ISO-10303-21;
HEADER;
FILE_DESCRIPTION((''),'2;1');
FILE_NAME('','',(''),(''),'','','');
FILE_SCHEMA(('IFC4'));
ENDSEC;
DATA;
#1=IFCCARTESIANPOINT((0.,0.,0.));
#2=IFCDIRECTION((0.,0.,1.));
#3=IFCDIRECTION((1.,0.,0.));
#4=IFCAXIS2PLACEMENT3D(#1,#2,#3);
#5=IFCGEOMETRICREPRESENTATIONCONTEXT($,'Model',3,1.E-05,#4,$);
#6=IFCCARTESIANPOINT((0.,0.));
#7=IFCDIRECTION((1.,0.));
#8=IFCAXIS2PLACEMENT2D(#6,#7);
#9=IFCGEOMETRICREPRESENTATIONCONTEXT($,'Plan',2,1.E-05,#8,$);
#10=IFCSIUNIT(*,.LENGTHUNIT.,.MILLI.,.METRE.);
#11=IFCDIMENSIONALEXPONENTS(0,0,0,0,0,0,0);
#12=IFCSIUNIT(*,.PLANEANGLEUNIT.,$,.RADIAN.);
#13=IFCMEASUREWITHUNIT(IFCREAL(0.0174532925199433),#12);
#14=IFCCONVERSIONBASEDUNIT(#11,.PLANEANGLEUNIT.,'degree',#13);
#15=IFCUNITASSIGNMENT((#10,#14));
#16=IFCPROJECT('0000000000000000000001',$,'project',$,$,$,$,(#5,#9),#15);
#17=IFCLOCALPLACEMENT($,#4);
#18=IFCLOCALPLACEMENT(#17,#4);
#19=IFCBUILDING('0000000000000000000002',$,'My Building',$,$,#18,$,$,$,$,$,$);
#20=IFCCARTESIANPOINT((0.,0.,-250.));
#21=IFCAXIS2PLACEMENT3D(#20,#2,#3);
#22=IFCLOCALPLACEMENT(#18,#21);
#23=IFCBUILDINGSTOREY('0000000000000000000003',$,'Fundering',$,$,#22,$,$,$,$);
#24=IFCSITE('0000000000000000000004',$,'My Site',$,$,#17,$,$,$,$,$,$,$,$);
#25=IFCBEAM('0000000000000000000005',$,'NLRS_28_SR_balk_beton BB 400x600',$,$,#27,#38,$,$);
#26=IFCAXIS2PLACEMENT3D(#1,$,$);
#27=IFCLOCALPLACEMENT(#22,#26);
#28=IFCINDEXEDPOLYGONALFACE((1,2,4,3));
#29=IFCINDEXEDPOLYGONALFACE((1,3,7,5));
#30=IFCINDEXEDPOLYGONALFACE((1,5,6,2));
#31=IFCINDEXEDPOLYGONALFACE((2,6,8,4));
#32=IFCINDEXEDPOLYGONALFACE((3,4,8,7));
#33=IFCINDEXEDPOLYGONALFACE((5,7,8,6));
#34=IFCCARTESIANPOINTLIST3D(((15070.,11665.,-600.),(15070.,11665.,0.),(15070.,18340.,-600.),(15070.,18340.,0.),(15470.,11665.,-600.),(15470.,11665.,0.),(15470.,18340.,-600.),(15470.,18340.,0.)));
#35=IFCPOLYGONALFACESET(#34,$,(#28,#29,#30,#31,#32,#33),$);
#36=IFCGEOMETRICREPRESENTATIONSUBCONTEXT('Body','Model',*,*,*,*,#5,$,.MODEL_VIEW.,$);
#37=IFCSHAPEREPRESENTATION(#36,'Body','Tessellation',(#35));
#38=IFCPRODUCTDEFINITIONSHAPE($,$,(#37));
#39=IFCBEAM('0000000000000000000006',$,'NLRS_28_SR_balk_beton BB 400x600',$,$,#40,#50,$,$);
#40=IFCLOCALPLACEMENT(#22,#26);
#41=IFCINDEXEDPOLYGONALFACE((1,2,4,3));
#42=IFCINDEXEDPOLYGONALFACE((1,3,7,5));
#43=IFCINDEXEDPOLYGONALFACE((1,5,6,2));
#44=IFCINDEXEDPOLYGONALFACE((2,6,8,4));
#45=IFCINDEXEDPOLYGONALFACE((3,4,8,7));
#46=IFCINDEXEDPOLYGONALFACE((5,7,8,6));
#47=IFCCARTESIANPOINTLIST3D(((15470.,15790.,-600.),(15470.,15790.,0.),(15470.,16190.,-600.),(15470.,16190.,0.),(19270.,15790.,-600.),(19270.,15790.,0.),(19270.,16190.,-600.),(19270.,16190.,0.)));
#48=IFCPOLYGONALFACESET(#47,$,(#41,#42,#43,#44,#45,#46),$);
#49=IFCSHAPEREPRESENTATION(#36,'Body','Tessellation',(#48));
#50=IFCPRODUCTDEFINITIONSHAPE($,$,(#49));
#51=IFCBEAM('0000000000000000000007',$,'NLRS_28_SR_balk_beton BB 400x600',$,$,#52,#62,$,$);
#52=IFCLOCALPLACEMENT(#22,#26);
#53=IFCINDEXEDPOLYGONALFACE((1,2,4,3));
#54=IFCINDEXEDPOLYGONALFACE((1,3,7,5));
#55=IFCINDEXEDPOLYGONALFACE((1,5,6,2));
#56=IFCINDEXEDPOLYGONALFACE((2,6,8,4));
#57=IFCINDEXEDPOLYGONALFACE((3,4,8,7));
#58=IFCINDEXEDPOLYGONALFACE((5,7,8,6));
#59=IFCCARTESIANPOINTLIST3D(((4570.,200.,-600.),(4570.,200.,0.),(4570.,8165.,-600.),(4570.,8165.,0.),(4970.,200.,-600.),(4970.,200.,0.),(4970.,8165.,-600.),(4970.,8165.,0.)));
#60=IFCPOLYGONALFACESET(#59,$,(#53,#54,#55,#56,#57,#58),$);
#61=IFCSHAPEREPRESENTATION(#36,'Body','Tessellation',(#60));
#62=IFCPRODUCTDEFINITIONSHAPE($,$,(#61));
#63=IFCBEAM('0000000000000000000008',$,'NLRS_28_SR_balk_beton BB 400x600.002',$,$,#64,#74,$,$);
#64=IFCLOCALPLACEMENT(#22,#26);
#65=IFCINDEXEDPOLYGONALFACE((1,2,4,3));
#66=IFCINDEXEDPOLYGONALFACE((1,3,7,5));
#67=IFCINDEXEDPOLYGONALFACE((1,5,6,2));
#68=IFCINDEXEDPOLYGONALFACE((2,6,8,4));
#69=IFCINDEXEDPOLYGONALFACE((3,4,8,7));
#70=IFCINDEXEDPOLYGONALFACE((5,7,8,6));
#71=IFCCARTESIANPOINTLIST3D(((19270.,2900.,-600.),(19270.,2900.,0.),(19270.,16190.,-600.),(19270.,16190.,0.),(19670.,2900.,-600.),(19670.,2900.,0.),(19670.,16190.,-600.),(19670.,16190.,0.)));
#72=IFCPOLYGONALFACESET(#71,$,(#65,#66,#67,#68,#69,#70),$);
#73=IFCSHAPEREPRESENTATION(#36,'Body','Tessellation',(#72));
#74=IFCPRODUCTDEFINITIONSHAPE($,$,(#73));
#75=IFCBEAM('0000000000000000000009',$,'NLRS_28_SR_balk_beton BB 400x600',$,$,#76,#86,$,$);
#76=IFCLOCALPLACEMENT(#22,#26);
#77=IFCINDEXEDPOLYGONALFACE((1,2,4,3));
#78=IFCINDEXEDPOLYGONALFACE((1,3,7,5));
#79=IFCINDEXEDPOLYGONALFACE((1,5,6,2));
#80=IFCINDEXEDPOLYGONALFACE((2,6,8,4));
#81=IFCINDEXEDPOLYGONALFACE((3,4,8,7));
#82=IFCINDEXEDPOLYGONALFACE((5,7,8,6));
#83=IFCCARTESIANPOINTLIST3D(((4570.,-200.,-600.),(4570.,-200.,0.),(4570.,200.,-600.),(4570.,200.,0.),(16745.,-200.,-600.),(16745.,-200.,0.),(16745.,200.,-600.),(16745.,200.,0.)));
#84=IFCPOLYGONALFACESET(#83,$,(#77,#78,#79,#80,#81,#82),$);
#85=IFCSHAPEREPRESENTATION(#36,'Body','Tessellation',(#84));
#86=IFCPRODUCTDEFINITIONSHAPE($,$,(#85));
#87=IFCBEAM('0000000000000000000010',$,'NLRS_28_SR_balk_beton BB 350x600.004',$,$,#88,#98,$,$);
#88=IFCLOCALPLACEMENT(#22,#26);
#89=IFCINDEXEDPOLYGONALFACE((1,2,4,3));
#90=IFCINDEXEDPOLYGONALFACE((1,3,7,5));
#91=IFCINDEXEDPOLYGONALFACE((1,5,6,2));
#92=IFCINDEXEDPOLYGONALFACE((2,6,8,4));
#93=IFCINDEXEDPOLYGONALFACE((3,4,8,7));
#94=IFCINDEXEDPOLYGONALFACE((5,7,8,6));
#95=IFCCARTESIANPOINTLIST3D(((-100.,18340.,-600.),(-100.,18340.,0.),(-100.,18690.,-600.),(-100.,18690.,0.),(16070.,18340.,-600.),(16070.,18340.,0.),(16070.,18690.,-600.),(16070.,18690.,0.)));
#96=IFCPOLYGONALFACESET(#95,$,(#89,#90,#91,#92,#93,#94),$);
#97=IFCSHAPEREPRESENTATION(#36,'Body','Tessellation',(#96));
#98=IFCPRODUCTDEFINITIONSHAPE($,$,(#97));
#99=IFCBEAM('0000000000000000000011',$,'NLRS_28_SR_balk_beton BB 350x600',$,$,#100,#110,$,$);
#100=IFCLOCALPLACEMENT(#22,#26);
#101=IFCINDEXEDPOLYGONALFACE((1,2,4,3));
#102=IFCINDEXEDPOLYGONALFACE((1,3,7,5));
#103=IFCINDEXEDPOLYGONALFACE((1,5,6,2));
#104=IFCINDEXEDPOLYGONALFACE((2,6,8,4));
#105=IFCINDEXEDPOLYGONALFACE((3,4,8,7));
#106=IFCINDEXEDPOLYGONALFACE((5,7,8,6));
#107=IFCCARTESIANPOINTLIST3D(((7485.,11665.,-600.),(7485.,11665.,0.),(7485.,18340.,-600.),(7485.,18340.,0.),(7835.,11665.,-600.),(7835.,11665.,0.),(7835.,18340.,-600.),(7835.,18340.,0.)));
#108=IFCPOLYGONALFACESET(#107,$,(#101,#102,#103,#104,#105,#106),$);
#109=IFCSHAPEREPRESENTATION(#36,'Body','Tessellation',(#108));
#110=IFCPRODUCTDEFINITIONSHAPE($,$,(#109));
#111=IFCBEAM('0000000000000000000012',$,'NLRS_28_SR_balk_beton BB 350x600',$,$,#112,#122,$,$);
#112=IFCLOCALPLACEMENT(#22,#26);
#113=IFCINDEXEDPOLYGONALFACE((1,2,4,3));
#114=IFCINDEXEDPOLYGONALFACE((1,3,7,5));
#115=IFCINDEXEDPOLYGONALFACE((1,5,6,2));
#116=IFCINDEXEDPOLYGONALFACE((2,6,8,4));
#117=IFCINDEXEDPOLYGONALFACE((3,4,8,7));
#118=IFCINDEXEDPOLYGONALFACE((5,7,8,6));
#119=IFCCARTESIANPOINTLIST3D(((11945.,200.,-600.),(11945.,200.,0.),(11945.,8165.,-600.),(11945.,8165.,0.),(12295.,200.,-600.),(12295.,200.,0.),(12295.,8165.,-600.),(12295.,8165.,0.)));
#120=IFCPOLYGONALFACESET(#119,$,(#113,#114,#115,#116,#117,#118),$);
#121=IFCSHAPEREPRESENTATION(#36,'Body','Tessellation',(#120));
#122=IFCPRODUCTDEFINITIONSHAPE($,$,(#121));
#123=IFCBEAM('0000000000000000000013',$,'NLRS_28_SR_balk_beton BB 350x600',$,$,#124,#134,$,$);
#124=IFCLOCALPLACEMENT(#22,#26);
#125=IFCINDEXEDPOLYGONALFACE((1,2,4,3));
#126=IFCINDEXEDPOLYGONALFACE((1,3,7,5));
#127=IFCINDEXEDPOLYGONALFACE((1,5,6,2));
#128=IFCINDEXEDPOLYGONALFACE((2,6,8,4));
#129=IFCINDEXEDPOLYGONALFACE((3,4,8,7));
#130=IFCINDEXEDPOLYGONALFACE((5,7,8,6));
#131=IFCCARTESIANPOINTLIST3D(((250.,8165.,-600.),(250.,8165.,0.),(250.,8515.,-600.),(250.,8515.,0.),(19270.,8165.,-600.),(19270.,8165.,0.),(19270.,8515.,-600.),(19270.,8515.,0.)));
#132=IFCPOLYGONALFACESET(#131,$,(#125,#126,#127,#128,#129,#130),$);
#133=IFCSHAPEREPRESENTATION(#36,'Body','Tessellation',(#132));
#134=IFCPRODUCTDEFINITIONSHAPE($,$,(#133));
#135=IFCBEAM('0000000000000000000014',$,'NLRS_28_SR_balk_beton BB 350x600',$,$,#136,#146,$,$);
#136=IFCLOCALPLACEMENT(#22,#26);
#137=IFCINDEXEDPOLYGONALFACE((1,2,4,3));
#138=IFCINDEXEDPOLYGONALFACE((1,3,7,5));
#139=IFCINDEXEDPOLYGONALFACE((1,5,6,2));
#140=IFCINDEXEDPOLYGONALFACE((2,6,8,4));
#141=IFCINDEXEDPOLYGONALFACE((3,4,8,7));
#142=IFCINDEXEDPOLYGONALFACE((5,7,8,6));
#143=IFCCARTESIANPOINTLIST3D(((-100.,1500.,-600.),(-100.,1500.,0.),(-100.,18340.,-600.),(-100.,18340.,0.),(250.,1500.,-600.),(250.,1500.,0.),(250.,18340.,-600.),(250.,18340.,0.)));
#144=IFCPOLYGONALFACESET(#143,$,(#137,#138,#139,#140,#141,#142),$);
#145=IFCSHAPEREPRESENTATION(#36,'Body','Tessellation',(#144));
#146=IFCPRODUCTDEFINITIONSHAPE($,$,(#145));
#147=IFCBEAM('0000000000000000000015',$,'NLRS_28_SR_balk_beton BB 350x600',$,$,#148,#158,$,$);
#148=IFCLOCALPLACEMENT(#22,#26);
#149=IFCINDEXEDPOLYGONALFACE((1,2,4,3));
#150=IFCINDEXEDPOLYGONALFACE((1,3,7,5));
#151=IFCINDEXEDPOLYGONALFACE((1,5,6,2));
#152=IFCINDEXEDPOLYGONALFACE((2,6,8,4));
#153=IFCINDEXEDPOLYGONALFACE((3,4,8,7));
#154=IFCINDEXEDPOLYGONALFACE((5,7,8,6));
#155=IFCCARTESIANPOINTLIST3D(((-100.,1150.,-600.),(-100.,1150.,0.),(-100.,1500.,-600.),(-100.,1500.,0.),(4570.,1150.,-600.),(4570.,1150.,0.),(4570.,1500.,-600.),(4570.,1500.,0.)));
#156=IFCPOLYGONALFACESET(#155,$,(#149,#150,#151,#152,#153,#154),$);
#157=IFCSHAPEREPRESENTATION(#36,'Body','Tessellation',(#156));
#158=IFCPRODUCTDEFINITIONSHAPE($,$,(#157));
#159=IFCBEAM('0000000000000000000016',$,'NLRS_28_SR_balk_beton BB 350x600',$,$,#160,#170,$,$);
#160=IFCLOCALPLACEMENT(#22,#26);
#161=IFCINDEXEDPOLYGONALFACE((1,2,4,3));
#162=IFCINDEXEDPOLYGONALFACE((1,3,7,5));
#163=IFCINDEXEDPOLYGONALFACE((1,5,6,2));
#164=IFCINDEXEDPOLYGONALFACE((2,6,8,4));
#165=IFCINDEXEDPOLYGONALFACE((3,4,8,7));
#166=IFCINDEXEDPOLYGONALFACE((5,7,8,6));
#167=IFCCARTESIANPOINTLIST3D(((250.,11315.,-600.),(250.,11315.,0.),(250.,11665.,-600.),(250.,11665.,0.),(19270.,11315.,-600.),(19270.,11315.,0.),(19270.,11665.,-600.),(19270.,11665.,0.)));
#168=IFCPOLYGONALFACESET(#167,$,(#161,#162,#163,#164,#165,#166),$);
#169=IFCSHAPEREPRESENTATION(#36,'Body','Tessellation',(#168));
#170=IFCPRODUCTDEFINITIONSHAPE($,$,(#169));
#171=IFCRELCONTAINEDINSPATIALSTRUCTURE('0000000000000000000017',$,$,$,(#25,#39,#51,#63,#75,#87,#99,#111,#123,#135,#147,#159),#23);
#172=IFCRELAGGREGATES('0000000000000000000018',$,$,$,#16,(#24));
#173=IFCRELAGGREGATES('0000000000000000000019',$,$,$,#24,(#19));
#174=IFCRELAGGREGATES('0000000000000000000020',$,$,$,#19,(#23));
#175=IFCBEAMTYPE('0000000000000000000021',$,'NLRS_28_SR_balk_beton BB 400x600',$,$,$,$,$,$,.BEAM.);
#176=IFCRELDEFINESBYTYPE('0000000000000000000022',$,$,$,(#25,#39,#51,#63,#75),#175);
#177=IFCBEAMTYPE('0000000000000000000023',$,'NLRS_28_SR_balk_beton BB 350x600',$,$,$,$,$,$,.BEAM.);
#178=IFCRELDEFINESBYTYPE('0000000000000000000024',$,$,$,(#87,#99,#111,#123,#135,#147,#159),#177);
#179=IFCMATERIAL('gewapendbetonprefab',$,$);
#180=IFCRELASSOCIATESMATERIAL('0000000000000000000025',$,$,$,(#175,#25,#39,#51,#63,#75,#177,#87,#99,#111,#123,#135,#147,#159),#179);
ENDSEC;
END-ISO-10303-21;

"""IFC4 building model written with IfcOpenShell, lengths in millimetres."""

from ifc_helpers import new_model, entity, si_unit, converted_unit, frame, origin_with_axes, origin_2d_with_axis, place, context, subcontext, project, spatial, rectangle, extrude, material, material_profile, profile_set, profile_usage, type_object, element, save


model = new_model("IFC4")

# Units and contexts
model_context = context("Model", 3, precision=1e-05, world=origin_with_axes())
plan_context = context("Plan", 2, precision=1e-05, world=origin_2d_with_axis())
body_context = subcontext(model_context, "Body", "Model", "MODEL_VIEW")
ifc_project = project(units=[si_unit("LENGTHUNIT", "METRE", prefix="MILLI"), converted_unit("PLANEANGLEUNIT", "degree", entity("IfcReal", 0.0174532925199433), si_unit("PLANEANGLEUNIT", "RADIAN"), dimensions=[0, 0, 0, 0, 0, 0, 0])], contexts=[model_context, plan_context])

# Site, building, storey
site_placement = place(None, origin_with_axes())
site = spatial("IfcSite", under=ifc_project, at=site_placement, Name="My Site")
building_placement = place(site_placement, origin_with_axes())
building = spatial("IfcBuilding", under=site, at=building_placement, Name="My Building")
storey_placement = place(building_placement, frame((0.0, 0.0, -250.0), z_axis=(0.0, 0.0, 1.0), x_axis=(1.0, 0.0, 0.0)))
storey = spatial("IfcBuildingStorey", under=building, at=storey_placement, Name="Fundering")

# Beams
ifc_material = material(Name="gewapendbetonprefab")
ifc_material_profile_1 = material_profile(ifc_material, rectangle(XDim=400.0, YDim=600.0))
ifc_profile_set_1 = profile_set([ifc_material_profile_1], Name="NLRS_28_SR_balk_beton BB 400x600")
ifc_profile_usage_1 = profile_usage(ifc_profile_set_1, cardinal=8)
beam_type_1 = type_object("IfcBeamType", Name="NLRS_28_SR_balk_beton BB 400x600", PredefinedType="BEAM", material=ifc_profile_set_1)
beam_1_placement = place(storey_placement, frame((15270.0, 11665.0, 0.0), z_axis=(0.0, 1.0, 0.0), x_axis=(-1.0, 0.0, 0.0)))
element("IfcBeam", 1, at=beam_1_placement, inside=storey, type_object=beam_type_1, material=ifc_profile_usage_1, Name="NLRS_28_SR_balk_beton BB 400x600", context=body_context, shape_type="SweptSolid", body=[
    extrude(rectangle(XDim=400.0, YDim=600.0), frame((0.0, -300.0, 0.0), z_axis=(0.0, 0.0, 1.0), x_axis=(1.0, 0.0, 0.0)), (0.0, 0.0, 1.0), 6675.0),
])
ifc_profile_usage_2 = profile_usage(ifc_profile_set_1, cardinal=8)
beam_2_placement = place(storey_placement, frame((19270.0, 15990.0, 0.0), z_axis=(-1.0, 0.0, 0.0), x_axis=(0.0, -1.0, 0.0)))
element("IfcBeam", 2, at=beam_2_placement, inside=storey, type_object=beam_type_1, material=ifc_profile_usage_2, Name="NLRS_28_SR_balk_beton BB 400x600", context=body_context, shape_type="SweptSolid", body=[
    extrude(rectangle(XDim=400.0, YDim=600.0), frame((0.0, -300.0, 0.0), z_axis=(0.0, 0.0, 1.0), x_axis=(1.0, 0.0, 0.0)), (0.0, 0.0, 1.0), 3800.0),
])
ifc_profile_usage_3 = profile_usage(ifc_profile_set_1, cardinal=8)
beam_3_placement = place(storey_placement, frame((4770.0, 200.0, 0.0), z_axis=(0.0, 1.0, 0.0), x_axis=(-1.0, 0.0, 0.0)))
element("IfcBeam", 3, at=beam_3_placement, inside=storey, type_object=beam_type_1, material=ifc_profile_usage_3, Name="NLRS_28_SR_balk_beton BB 400x600", context=body_context, shape_type="SweptSolid", body=[
    extrude(rectangle(XDim=400.0, YDim=600.0), frame((0.0, -300.0, 0.0), z_axis=(0.0, 0.0, 1.0), x_axis=(1.0, 0.0, 0.0)), (0.0, 0.0, 1.0), 7965.0),
])
ifc_profile_usage_4 = profile_usage(ifc_profile_set_1, cardinal=8)
beam_4_placement = place(storey_placement, frame((19470.0, 2900.0, 0.0), z_axis=(0.0, 1.0, 0.0), x_axis=(-1.0, 0.0, 0.0)))
element("IfcBeam", 4, at=beam_4_placement, inside=storey, type_object=beam_type_1, material=ifc_profile_usage_4, Name="NLRS_28_SR_balk_beton BB 400x600.002", context=body_context, shape_type="SweptSolid", body=[
    extrude(rectangle(XDim=400.0, YDim=600.0), frame((0.0, -300.0, 0.0), z_axis=(0.0, 0.0, 1.0), x_axis=(1.0, 0.0, 0.0)), (0.0, 0.0, 1.0), 13290.0),
])
ifc_profile_usage_5 = profile_usage(ifc_profile_set_1, cardinal=8)
beam_5_placement = place(storey_placement, frame((4570.0, 0.0, 0.0), z_axis=(1.0, 0.0, 0.0), x_axis=(0.0, 1.0, 0.0)))
element("IfcBeam", 5, at=beam_5_placement, inside=storey, type_object=beam_type_1, material=ifc_profile_usage_5, Name="NLRS_28_SR_balk_beton BB 400x600", context=body_context, shape_type="SweptSolid", body=[
    extrude(rectangle(XDim=400.0, YDim=600.0), frame((0.0, -300.0, 0.0), z_axis=(0.0, 0.0, 1.0), x_axis=(1.0, 0.0, 0.0)), (0.0, 0.0, 1.0), 12175.0),
])
ifc_material_profile_2 = material_profile(ifc_material, rectangle(XDim=350.0, YDim=600.0))
ifc_profile_set_2 = profile_set([ifc_material_profile_2], Name="NLRS_28_SR_balk_beton BB 350x600")
ifc_profile_usage_6 = profile_usage(ifc_profile_set_2, cardinal=8)
beam_type_2 = type_object("IfcBeamType", Name="NLRS_28_SR_balk_beton BB 350x600", PredefinedType="BEAM", material=ifc_profile_set_2)
beam_6_placement = place(storey_placement, frame((-100.0, 18515.0, 0.0), z_axis=(1.0, 0.0, 0.0), x_axis=(0.0, 1.0, 0.0)))
element("IfcBeam", 6, at=beam_6_placement, inside=storey, type_object=beam_type_2, material=ifc_profile_usage_6, Name="NLRS_28_SR_balk_beton BB 350x600.004", context=body_context, shape_type="SweptSolid", body=[
    extrude(rectangle(XDim=350.0, YDim=600.0), frame((0.0, -300.0, 0.0)), (0.0, 0.0, 1.0), 16170.0),
])
ifc_profile_usage_7 = profile_usage(ifc_profile_set_2, cardinal=8)
beam_7_placement = place(storey_placement, frame((7660.0, 11665.0, 0.0), z_axis=(0.0, 1.0, 0.0), x_axis=(-1.0, 0.0, 0.0)))
element("IfcBeam", 7, at=beam_7_placement, inside=storey, type_object=beam_type_2, material=ifc_profile_usage_7, Name="NLRS_28_SR_balk_beton BB 350x600", context=body_context, shape_type="SweptSolid", body=[
    extrude(rectangle(XDim=350.0, YDim=600.0), frame((0.0, -300.0, 0.0), z_axis=(0.0, 0.0, 1.0), x_axis=(1.0, 0.0, 0.0)), (0.0, 0.0, 1.0), 6675.0),
])
ifc_profile_usage_8 = profile_usage(ifc_profile_set_2)
beam_8_placement = place(storey_placement, frame((12120.0, 200.0, -300.0), z_axis=(0.0, 1.0, 0.0), x_axis=(-1.0, 0.0, 0.0)))
element("IfcBeam", 8, at=beam_8_placement, inside=storey, type_object=beam_type_2, material=ifc_profile_usage_8, Name="NLRS_28_SR_balk_beton BB 350x600", context=body_context, shape_type="SweptSolid", body=[
    extrude(rectangle(XDim=350.0, YDim=600.0), origin_with_axes(), (0.0, 0.0, 1.0), 7965.0),
])
ifc_profile_usage_9 = profile_usage(ifc_profile_set_2, cardinal=8)
beam_9_placement = place(storey_placement, frame((19270.0, 8340.0, 0.0), z_axis=(-1.0, 0.0, 0.0), x_axis=(0.0, -1.0, 0.0)))
element("IfcBeam", 9, at=beam_9_placement, inside=storey, type_object=beam_type_2, material=ifc_profile_usage_9, Name="NLRS_28_SR_balk_beton BB 350x600", context=body_context, shape_type="SweptSolid", body=[
    extrude(rectangle(XDim=350.0, YDim=600.0), frame((0.0, -300.0, 0.0), z_axis=(0.0, 0.0, 1.0), x_axis=(1.0, 0.0, 0.0)), (0.0, 0.0, 1.0), 19020.0),
])
ifc_profile_usage_10 = profile_usage(ifc_profile_set_2, cardinal=8)
beam_10_placement = place(storey_placement, frame((75.0, 1500.0, 0.0), z_axis=(0.0, 1.0, 0.0), x_axis=(-1.0, 0.0, 0.0)))
element("IfcBeam", 10, at=beam_10_placement, inside=storey, type_object=beam_type_2, material=ifc_profile_usage_10, Name="NLRS_28_SR_balk_beton BB 350x600", context=body_context, shape_type="SweptSolid", body=[
    extrude(rectangle(XDim=350.0, YDim=600.0), frame((0.0, -300.0, 0.0), z_axis=(0.0, 0.0, 1.0), x_axis=(1.0, 0.0, 0.0)), (0.0, 0.0, 1.0), 16840.0),
])
ifc_profile_usage_11 = profile_usage(ifc_profile_set_2, cardinal=8)
beam_11_placement = place(storey_placement, frame((4570.0, 1325.0, 0.0), z_axis=(-1.0, 0.0, 0.0), x_axis=(0.0, -1.0, 0.0)))
element("IfcBeam", 11, at=beam_11_placement, inside=storey, type_object=beam_type_2, material=ifc_profile_usage_11, Name="NLRS_28_SR_balk_beton BB 350x600", context=body_context, shape_type="SweptSolid", body=[
    extrude(rectangle(XDim=350.0, YDim=600.0), frame((0.0, -300.0, 0.0), z_axis=(0.0, 0.0, 1.0), x_axis=(1.0, 0.0, 0.0)), (0.0, 0.0, 1.0), 4670.0),
])
ifc_profile_usage_12 = profile_usage(ifc_profile_set_2, cardinal=8)
beam_12_placement = place(storey_placement, frame((19270.0, 11490.0, 0.0), z_axis=(-1.0, 0.0, 0.0), x_axis=(0.0, -1.0, 0.0)))
element("IfcBeam", 12, at=beam_12_placement, inside=storey, type_object=beam_type_2, material=ifc_profile_usage_12, Name="NLRS_28_SR_balk_beton BB 350x600", context=body_context, shape_type="SweptSolid", body=[
    extrude(rectangle(XDim=350.0, YDim=600.0), frame((0.0, -300.0, 0.0), z_axis=(0.0, 0.0, 1.0), x_axis=(1.0, 0.0, 0.0)), (0.0, 0.0, 1.0), 19020.0),
])

save(model, "model.ifc")
